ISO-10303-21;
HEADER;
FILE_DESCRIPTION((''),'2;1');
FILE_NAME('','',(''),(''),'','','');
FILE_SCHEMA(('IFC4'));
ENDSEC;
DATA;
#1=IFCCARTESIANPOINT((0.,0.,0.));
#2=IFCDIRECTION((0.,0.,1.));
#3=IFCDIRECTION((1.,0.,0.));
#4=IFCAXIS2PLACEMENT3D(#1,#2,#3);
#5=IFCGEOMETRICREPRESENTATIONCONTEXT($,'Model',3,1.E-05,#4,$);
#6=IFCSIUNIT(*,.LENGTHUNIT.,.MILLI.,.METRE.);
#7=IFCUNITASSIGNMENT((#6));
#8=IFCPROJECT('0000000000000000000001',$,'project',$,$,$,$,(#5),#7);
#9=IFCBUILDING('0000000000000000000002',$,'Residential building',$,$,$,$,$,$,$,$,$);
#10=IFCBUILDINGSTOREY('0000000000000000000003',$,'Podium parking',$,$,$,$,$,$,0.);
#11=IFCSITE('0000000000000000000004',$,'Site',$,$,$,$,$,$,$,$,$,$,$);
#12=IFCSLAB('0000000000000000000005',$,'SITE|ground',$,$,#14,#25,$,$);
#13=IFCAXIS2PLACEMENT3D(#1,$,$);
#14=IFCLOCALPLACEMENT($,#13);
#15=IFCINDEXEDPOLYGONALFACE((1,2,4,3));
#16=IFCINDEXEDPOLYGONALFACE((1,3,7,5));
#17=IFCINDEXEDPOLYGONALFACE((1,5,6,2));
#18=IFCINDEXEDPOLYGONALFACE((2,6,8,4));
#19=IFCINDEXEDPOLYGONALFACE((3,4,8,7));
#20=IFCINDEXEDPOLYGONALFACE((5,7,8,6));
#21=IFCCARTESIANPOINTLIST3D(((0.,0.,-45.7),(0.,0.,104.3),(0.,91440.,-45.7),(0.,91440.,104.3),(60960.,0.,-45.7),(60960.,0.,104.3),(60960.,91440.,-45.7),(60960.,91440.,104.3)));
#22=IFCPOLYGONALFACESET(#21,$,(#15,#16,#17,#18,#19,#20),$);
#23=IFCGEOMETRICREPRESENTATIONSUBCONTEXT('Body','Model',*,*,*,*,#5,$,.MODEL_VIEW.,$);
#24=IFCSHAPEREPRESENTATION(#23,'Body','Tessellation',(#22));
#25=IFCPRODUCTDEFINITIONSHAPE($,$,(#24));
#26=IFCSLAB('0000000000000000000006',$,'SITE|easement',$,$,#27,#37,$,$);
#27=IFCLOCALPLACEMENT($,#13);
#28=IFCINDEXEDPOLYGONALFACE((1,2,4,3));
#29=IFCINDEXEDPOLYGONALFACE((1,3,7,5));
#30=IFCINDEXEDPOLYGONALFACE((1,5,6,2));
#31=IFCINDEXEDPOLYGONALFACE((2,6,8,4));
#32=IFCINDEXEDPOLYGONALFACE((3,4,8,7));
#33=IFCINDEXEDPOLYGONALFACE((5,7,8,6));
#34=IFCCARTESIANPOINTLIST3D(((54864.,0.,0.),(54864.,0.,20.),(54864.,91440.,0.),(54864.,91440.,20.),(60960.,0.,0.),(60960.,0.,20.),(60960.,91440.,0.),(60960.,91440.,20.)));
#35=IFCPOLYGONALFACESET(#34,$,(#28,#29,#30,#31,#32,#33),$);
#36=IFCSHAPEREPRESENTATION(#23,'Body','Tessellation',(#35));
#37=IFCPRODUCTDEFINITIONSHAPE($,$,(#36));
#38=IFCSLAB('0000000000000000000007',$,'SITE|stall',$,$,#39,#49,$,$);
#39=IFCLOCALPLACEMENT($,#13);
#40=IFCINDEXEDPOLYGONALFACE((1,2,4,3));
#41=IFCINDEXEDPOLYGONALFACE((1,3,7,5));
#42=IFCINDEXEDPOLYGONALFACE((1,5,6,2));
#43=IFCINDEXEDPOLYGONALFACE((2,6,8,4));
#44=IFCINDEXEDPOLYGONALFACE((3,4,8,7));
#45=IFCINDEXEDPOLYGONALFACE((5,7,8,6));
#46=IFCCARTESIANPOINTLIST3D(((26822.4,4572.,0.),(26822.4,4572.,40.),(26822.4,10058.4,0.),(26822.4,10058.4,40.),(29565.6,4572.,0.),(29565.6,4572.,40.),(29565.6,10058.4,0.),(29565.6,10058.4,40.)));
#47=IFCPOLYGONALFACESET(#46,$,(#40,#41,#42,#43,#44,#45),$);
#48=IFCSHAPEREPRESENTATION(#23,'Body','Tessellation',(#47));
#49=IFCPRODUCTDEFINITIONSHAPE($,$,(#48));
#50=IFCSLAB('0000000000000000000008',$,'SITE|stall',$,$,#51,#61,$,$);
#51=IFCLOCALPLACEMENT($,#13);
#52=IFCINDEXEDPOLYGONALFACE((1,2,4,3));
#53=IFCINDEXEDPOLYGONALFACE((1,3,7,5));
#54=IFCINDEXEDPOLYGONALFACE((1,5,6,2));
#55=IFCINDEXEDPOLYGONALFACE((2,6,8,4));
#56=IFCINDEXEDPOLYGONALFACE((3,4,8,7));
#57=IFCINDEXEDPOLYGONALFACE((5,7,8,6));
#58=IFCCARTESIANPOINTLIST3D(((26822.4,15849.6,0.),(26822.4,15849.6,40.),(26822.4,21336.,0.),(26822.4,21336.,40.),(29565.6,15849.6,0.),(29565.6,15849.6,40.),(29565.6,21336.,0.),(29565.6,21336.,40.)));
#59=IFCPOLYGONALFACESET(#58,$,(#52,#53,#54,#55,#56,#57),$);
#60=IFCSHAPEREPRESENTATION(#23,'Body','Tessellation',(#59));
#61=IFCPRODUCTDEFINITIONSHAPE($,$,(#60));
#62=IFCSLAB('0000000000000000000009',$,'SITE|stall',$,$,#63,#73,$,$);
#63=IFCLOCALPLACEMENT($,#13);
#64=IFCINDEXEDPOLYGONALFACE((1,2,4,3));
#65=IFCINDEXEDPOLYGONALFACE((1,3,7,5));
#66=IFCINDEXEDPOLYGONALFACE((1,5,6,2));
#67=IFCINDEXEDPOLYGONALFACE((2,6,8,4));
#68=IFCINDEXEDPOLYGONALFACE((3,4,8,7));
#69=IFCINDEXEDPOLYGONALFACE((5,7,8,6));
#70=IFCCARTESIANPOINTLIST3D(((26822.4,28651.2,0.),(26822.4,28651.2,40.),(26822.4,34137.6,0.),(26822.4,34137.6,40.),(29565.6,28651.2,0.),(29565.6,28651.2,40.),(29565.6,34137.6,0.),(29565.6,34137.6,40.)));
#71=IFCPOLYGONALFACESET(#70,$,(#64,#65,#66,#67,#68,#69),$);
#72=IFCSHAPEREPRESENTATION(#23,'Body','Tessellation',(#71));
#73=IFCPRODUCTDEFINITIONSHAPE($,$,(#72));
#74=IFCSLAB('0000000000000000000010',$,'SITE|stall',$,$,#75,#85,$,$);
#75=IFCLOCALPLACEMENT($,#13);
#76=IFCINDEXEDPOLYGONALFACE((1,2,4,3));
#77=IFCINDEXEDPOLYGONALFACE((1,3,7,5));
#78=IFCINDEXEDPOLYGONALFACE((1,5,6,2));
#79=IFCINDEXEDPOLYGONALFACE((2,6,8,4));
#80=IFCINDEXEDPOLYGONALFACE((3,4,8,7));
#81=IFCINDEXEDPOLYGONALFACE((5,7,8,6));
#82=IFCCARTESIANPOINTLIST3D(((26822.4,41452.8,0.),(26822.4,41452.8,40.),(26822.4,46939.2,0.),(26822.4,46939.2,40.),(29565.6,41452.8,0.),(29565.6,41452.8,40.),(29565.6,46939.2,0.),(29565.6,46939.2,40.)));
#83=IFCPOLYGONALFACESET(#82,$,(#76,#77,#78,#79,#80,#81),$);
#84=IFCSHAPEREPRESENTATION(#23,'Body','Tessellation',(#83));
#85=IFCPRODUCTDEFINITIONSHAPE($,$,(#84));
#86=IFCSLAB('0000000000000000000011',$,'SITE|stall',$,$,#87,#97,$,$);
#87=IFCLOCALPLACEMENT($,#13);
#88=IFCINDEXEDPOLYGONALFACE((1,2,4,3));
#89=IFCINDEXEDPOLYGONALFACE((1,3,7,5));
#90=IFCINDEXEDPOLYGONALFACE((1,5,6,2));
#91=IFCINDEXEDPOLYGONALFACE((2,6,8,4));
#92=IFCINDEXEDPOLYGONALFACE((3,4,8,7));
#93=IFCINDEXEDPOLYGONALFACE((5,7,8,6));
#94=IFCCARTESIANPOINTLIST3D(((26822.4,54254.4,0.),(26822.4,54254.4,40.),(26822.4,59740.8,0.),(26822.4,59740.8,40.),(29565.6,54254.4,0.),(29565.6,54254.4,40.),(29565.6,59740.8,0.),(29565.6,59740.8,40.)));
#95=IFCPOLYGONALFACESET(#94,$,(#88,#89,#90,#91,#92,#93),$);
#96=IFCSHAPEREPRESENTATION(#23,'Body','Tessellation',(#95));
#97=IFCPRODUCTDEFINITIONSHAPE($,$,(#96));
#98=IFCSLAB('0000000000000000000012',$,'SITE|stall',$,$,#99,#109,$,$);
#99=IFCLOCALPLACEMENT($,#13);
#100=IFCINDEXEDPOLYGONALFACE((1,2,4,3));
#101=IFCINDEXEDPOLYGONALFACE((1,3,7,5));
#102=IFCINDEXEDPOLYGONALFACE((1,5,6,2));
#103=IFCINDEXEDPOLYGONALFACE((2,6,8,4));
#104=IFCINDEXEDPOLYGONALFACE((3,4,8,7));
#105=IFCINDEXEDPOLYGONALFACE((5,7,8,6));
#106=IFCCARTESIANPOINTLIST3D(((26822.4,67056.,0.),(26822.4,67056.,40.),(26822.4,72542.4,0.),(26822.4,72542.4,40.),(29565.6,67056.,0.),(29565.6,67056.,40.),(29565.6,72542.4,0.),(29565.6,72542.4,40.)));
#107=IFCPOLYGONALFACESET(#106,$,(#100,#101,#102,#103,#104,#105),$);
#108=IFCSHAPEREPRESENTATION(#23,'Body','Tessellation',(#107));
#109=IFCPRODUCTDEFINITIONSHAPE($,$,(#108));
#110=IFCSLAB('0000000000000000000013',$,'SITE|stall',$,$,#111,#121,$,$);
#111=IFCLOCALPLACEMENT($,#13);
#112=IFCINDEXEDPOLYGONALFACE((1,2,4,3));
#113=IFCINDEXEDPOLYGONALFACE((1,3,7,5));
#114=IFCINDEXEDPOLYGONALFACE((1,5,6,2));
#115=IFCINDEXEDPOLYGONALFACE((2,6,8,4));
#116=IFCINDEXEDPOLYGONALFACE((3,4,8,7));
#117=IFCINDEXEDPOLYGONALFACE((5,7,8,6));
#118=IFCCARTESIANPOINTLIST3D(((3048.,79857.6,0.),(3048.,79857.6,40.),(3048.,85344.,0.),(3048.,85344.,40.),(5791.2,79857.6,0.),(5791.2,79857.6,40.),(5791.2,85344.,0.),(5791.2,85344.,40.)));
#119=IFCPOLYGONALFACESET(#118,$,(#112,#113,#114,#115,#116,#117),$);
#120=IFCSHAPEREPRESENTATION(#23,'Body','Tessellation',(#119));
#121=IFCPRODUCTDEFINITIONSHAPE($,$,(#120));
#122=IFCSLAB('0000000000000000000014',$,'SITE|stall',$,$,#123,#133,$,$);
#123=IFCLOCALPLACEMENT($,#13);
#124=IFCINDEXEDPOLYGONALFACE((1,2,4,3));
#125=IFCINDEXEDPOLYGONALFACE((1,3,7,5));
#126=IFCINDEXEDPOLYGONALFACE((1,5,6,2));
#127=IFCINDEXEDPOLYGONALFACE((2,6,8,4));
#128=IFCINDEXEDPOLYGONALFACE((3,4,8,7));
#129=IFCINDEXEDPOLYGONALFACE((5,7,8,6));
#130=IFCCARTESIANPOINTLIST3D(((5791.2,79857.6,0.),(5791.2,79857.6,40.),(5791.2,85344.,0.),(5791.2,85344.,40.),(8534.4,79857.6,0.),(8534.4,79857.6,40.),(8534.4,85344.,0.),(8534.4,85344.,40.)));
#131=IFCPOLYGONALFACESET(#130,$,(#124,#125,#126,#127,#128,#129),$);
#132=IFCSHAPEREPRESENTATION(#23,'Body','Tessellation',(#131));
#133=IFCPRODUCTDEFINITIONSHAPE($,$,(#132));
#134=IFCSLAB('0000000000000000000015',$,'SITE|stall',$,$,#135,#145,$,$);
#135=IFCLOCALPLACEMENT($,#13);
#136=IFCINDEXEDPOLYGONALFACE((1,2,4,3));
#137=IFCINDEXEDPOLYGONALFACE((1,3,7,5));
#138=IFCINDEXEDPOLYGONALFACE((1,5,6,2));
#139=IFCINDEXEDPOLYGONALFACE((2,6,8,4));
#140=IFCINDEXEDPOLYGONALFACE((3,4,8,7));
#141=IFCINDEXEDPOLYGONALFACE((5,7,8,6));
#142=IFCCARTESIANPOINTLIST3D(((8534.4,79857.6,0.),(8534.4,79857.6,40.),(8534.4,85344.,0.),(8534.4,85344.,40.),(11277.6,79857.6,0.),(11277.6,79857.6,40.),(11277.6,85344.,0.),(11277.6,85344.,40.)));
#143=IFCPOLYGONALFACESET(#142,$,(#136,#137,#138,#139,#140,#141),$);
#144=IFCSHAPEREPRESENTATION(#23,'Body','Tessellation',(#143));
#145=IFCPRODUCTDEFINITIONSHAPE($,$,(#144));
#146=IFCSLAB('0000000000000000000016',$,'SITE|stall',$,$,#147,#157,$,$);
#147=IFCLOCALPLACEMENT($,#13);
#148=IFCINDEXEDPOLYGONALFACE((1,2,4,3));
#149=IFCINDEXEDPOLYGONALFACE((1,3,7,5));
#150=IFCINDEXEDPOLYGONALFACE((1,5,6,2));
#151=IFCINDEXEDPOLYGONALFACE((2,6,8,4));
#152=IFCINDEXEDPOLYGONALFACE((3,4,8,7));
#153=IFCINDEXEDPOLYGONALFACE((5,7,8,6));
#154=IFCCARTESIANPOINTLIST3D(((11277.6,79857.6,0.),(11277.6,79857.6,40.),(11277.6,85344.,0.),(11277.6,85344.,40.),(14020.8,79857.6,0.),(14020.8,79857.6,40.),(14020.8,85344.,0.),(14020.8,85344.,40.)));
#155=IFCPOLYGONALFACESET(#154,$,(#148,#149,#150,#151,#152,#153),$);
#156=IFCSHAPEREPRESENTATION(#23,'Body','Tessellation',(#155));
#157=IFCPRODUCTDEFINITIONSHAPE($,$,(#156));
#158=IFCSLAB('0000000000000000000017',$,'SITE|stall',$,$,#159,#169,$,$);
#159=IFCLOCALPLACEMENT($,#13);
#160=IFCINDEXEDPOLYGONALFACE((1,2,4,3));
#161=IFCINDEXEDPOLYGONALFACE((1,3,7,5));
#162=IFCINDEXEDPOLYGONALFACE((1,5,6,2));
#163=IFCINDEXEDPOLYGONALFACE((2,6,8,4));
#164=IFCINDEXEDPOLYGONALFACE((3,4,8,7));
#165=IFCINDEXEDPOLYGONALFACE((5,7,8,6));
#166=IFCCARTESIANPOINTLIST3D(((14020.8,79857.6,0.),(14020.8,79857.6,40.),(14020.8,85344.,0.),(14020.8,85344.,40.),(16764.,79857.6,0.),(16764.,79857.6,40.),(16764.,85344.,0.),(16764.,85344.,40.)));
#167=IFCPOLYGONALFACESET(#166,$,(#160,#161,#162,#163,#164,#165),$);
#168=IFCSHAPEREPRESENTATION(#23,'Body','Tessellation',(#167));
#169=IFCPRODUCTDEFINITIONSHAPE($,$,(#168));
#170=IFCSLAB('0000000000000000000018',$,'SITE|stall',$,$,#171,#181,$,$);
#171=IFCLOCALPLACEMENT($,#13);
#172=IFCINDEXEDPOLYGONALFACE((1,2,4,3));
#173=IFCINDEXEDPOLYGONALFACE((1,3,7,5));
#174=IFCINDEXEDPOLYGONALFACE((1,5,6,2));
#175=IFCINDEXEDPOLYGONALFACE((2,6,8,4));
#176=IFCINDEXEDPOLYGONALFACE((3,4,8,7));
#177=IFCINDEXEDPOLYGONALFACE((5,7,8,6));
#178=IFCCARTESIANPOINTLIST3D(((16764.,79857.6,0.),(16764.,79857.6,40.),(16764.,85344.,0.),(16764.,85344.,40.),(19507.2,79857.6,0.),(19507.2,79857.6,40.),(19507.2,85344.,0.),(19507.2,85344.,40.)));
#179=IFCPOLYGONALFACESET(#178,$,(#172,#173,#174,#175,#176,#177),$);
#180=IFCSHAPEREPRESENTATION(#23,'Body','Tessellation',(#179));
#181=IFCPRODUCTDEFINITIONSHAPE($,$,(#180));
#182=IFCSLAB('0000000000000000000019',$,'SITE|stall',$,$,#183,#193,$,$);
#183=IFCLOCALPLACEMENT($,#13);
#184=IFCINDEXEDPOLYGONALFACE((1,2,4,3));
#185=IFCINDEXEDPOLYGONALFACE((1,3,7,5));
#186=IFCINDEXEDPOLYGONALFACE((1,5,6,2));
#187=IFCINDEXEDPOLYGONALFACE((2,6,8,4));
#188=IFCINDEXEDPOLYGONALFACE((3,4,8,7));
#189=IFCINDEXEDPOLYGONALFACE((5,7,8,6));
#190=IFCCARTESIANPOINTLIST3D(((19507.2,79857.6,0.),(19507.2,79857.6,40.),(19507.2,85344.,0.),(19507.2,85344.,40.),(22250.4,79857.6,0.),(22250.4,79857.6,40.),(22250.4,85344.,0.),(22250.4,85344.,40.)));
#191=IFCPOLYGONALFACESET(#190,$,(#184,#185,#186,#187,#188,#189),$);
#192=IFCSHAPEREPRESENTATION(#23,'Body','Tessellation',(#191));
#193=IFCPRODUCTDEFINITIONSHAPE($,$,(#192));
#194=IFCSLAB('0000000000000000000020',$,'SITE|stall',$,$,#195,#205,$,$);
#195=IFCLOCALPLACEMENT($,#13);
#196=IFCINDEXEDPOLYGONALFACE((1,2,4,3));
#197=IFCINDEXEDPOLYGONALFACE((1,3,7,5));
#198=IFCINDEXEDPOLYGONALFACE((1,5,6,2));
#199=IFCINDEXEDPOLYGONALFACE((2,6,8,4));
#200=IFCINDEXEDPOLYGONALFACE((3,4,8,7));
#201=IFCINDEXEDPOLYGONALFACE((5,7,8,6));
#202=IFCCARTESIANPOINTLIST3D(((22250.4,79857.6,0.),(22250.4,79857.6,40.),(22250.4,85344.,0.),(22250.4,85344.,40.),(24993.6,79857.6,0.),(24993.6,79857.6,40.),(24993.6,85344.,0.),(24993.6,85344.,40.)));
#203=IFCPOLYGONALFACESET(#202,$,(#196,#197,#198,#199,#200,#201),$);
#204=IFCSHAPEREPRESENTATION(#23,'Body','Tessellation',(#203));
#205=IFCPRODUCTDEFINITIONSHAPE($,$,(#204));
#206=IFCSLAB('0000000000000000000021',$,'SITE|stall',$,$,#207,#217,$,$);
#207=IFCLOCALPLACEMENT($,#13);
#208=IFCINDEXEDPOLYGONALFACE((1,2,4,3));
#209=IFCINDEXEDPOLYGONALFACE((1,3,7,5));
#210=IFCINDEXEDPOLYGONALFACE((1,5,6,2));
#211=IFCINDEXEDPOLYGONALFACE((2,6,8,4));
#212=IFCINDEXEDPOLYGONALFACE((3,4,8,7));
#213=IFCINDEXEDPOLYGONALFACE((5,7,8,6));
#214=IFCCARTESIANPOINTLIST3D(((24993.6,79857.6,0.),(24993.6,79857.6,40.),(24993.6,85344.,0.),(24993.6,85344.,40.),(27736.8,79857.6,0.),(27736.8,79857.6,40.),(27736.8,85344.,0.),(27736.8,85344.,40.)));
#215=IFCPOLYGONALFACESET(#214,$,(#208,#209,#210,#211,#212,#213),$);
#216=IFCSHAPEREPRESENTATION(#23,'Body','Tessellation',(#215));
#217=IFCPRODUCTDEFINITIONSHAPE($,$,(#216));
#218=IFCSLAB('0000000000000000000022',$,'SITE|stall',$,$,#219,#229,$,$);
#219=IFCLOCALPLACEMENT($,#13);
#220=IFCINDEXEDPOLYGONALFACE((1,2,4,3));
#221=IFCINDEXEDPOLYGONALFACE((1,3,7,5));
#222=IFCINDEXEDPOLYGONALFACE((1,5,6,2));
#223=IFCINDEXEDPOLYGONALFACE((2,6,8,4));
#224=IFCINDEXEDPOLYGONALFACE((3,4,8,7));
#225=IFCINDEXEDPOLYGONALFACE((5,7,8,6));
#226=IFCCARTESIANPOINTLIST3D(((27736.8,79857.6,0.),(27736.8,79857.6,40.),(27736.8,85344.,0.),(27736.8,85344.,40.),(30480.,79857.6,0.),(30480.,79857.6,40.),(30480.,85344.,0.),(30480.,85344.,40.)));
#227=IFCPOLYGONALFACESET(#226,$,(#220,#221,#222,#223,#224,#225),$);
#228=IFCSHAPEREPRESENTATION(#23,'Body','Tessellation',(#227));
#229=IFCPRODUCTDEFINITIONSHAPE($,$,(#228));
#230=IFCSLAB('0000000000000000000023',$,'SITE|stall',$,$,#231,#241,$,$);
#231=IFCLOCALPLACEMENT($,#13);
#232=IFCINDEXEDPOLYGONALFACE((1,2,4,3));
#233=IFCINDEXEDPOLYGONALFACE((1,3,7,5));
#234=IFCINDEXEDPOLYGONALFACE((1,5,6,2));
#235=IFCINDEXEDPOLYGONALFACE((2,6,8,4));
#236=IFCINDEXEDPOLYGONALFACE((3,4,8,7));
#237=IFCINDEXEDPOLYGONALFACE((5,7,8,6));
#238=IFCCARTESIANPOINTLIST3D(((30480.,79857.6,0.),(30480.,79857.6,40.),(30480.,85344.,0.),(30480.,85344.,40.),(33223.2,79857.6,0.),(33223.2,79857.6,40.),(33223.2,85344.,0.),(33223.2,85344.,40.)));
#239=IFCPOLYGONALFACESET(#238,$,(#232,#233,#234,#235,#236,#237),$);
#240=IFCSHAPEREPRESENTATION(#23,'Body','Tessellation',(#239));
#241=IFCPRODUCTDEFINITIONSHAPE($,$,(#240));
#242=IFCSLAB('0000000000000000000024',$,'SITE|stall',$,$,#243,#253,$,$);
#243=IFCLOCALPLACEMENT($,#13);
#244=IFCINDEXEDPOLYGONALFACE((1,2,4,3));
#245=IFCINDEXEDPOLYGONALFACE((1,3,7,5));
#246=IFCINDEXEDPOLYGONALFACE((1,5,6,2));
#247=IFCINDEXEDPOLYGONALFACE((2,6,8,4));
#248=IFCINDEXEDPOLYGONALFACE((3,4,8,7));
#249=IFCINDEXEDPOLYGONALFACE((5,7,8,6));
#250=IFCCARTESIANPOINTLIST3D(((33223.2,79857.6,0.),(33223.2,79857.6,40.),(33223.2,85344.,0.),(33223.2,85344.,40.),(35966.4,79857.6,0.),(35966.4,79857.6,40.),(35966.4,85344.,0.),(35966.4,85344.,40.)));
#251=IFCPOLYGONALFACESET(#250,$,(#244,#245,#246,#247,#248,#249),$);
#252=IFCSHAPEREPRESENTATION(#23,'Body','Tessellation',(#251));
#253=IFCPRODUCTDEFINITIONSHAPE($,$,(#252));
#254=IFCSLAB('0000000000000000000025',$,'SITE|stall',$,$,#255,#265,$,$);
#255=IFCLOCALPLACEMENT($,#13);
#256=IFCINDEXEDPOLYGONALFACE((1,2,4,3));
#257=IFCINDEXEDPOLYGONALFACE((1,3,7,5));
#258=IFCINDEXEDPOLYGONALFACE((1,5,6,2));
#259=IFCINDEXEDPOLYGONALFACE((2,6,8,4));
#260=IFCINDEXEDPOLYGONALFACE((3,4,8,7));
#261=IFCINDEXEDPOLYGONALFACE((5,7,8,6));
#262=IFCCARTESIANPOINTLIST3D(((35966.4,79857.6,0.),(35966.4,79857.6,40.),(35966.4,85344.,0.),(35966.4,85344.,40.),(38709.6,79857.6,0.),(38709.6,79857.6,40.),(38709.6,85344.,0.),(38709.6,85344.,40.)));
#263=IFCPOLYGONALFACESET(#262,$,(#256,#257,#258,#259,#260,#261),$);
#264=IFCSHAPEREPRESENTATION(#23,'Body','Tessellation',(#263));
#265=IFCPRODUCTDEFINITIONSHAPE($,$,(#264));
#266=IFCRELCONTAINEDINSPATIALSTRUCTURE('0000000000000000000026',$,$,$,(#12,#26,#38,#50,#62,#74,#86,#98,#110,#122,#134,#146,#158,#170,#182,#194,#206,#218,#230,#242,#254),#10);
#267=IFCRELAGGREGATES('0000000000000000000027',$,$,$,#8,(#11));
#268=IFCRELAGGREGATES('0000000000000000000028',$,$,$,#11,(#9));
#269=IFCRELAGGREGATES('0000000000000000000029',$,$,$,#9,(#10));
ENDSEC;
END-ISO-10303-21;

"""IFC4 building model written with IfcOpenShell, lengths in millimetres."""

from ifc_helpers import new_model, si_unit, frame, origin_with_axes, place, context, subcontext, project, spatial, indexed_curve, outline, extrude, element, save


model = new_model("IFC4")

# Units and contexts
model_context = context("Model", 3, precision=1e-05, world=origin_with_axes())
body_context = subcontext(model_context, "Body", "Model", "MODEL_VIEW")
ifc_project = project(units=[si_unit("LENGTHUNIT", "METRE", prefix="MILLI")], contexts=[model_context])

# Site, building, storey
site = spatial("IfcSite", under=ifc_project, Name="Site")
building = spatial("IfcBuilding", under=site, Name="Residential building")
storey = spatial("IfcBuildingStorey", under=building, Name="Podium parking", Elevation=0.0)

# Slabs
slab_1_placement = place(None, frame((0.0, 0.0, -45.7), z_axis=(0.0, 0.0, 1.0), x_axis=(1.0, 0.0, 0.0)))
element("IfcSlab", 1, at=slab_1_placement, inside=storey, Name="SITE|ground", context=body_context, shape_type="SweptSolid", body=[
    extrude(outline(indexed_curve([(0.0, 0.0), (60960.0, 0.0), (60960.0, 91440.0), (0.0, 91440.0), (0.0, 0.0)])), None, (0.0, 0.0, 1.0), 150.0),
])
slab_2_placement = place(None, frame((54864.0, 0.0, 0.0), z_axis=(0.0, 0.0, 1.0), x_axis=(1.0, 0.0, 0.0)))
element("IfcSlab", 2, at=slab_2_placement, inside=storey, Name="SITE|easement", context=body_context, shape_type="SweptSolid", body=[
    extrude(outline(indexed_curve([(0.0, 0.0), (6096.0, 0.0), (6096.0, 91440.0), (0.0, 91440.0), (0.0, 0.0)])), None, (0.0, 0.0, 1.0), 20.0),
])
for number, where, z_axis, x_axis, name in (
    (3, (26822.4, 4572.0, 0.0), (0.0, 0.0, 1.0), (1.0, 0.0, 0.0), "SITE|stall"),
    (4, (26822.4, 15849.6, 0.0), (0.0, 0.0, 1.0), (1.0, 0.0, 0.0), "SITE|stall"),
    (5, (26822.4, 28651.2, 0.0), (0.0, 0.0, 1.0), (1.0, 0.0, 0.0), "SITE|stall"),
    (6, (26822.4, 41452.8, 0.0), (0.0, 0.0, 1.0), (1.0, 0.0, 0.0), "SITE|stall"),
    (7, (26822.4, 54254.4, 0.0), (0.0, 0.0, 1.0), (1.0, 0.0, 0.0), "SITE|stall"),
    (8, (26822.4, 67056.0, 0.0), (0.0, 0.0, 1.0), (1.0, 0.0, 0.0), "SITE|stall"),
    (9, (3048.0, 79857.6, 0.0), (0.0, 0.0, 1.0), (1.0, 0.0, 0.0), "SITE|stall"),
    (10, (5791.2, 79857.6, 0.0), (0.0, 0.0, 1.0), (1.0, 0.0, 0.0), "SITE|stall"),
    (11, (8534.4, 79857.6, 0.0), (0.0, 0.0, 1.0), (1.0, 0.0, 0.0), "SITE|stall"),
    (12, (11277.6, 79857.6, 0.0), (0.0, 0.0, 1.0), (1.0, 0.0, 0.0), "SITE|stall"),
    (13, (14020.8, 79857.6, 0.0), (0.0, 0.0, 1.0), (1.0, 0.0, 0.0), "SITE|stall"),
    (14, (16764.0, 79857.6, 0.0), (0.0, 0.0, 1.0), (1.0, 0.0, 0.0), "SITE|stall"),
    (15, (19507.2, 79857.6, 0.0), (0.0, 0.0, 1.0), (1.0, 0.0, 0.0), "SITE|stall"),
    (16, (22250.4, 79857.6, 0.0), (0.0, 0.0, 1.0), (1.0, 0.0, 0.0), "SITE|stall"),
    (17, (24993.6, 79857.6, 0.0), (0.0, 0.0, 1.0), (1.0, 0.0, 0.0), "SITE|stall"),
    (18, (27736.8, 79857.6, 0.0), (0.0, 0.0, 1.0), (1.0, 0.0, 0.0), "SITE|stall"),
    (19, (30480.0, 79857.6, 0.0), (0.0, 0.0, 1.0), (1.0, 0.0, 0.0), "SITE|stall"),
    (20, (33223.2, 79857.6, 0.0), (0.0, 0.0, 1.0), (1.0, 0.0, 0.0), "SITE|stall"),
    (21, (35966.4, 79857.6, 0.0), (0.0, 0.0, 1.0), (1.0, 0.0, 0.0), "SITE|stall"),
):
    element("IfcSlab", number, at=place(None, frame(where, z_axis=z_axis, x_axis=x_axis)), inside=storey, Name=name, context=body_context, shape_type="SweptSolid", body=[
        extrude(outline(indexed_curve([(0.0, 0.0), (2743.2, 0.0), (2743.2, 5486.4), (0.0, 5486.4), (0.0, 0.0)])), None, (0.0, 0.0, 1.0), 40.0),
    ])

save(model, "model.ifc")
